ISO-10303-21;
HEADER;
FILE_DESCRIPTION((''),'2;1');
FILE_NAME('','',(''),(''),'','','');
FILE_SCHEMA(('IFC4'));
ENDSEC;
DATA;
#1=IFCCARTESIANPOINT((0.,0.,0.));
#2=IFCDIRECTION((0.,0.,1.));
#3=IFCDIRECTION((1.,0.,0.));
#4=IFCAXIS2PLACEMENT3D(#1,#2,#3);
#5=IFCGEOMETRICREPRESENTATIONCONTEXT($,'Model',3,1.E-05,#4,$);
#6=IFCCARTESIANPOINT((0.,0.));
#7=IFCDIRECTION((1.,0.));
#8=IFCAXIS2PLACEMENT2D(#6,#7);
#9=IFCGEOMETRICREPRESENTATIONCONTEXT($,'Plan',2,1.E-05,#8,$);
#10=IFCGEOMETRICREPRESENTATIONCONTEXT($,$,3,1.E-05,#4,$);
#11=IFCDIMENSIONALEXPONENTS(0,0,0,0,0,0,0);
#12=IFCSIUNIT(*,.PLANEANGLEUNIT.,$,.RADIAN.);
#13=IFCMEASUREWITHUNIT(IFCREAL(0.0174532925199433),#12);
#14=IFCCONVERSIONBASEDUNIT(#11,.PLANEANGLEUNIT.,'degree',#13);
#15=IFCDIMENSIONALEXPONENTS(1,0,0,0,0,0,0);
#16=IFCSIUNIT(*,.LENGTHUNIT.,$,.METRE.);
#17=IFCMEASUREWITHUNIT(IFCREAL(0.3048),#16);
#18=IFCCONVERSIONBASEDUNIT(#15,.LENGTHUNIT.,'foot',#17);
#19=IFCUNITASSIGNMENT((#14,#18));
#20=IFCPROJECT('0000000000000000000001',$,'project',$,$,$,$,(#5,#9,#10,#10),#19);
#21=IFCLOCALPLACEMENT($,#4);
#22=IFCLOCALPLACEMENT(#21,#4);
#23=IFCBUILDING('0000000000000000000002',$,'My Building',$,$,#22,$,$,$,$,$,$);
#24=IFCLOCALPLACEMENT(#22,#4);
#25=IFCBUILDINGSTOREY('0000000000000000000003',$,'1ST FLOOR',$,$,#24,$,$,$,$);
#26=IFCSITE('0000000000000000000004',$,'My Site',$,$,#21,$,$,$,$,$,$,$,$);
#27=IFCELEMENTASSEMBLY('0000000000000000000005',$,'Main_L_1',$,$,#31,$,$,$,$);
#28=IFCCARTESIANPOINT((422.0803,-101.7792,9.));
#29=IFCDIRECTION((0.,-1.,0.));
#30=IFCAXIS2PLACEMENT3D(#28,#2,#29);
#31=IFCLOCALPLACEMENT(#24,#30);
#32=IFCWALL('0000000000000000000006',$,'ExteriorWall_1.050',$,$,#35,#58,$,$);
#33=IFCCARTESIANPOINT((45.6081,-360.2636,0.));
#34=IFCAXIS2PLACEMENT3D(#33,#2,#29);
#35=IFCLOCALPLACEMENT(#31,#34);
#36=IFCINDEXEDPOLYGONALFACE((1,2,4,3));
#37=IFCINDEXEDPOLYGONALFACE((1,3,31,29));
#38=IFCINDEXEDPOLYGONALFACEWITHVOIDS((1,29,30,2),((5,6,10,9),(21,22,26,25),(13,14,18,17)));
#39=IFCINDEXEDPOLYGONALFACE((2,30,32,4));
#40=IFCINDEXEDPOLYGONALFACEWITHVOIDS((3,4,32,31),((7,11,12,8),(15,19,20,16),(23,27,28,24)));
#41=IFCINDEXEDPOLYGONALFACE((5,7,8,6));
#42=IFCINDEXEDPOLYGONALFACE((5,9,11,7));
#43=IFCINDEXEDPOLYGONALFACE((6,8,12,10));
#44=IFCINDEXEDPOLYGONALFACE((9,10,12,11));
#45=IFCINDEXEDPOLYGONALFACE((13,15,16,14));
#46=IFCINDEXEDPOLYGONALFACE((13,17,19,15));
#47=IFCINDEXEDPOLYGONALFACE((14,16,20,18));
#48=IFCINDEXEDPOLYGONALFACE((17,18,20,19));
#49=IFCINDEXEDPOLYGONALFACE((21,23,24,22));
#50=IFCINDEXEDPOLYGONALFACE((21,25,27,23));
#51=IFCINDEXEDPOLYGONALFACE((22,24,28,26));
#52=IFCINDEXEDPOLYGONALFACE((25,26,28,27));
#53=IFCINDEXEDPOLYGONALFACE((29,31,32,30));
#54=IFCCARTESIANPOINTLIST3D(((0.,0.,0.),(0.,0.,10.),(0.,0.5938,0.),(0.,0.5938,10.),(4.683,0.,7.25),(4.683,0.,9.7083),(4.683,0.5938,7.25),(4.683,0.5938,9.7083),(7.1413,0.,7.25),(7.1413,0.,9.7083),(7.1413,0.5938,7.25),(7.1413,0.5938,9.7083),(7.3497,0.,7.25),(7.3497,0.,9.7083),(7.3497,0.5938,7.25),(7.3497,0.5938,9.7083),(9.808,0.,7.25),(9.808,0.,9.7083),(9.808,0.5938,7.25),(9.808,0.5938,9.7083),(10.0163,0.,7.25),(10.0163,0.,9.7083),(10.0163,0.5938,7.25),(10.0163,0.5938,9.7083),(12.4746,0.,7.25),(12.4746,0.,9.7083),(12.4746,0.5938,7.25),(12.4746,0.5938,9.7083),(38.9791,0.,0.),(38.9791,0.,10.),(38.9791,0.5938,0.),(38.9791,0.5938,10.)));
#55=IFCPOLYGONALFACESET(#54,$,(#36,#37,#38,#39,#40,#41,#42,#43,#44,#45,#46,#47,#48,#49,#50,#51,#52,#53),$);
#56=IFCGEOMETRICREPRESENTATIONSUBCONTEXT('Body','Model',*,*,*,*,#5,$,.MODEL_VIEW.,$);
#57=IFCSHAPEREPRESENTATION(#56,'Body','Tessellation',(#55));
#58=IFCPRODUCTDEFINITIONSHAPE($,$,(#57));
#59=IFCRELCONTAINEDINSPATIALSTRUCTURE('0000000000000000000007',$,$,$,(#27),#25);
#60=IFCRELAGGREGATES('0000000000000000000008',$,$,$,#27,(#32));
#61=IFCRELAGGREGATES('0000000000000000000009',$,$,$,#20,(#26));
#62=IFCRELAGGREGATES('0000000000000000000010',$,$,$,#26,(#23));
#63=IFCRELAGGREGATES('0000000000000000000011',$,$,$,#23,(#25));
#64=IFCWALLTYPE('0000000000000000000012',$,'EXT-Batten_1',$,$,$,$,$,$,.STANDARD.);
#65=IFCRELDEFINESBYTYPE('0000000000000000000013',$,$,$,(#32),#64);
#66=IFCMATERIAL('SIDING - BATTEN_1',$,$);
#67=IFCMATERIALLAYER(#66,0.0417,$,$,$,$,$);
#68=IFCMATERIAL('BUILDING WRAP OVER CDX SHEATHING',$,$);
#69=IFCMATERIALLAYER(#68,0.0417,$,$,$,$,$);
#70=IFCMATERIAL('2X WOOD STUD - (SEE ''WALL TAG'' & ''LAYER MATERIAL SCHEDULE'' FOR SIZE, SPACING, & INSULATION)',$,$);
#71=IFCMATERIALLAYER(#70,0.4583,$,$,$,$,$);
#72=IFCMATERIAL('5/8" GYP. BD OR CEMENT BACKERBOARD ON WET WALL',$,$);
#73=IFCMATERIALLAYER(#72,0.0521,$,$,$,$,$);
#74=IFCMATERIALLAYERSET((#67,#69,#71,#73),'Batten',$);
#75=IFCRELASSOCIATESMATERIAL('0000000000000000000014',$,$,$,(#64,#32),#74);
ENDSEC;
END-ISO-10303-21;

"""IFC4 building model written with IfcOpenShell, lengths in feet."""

from ifc_helpers import new_model, entity, si_unit, converted_unit, frame, origin_with_axes, origin_2d_with_axis, place, context, subcontext, project, spatial, line, indexed_curve, outline, extrude, source, transform, mapped, material, layer, layer_set, layer_usage, type_object, element, aggregate, save


model = new_model("IFC4")

# Units and contexts
model_context = context("Model", 3, precision=1e-05, world=origin_with_axes())
plan_context = context("Plan", 2, precision=1e-05, world=origin_2d_with_axis())
context_of_model = context(None, 3, precision=1e-05, world=origin_with_axes())
body_context = subcontext(model_context, "Body", "Model", "MODEL_VIEW")
ifc_project = project(units=[converted_unit("PLANEANGLEUNIT", "degree", entity("IfcReal", 0.0174532925199433), si_unit("PLANEANGLEUNIT", "RADIAN"), dimensions=[0, 0, 0, 0, 0, 0, 0]), converted_unit("LENGTHUNIT", "foot", entity("IfcReal", 0.3048), si_unit("LENGTHUNIT", "METRE"), dimensions=[1, 0, 0, 0, 0, 0, 0])], contexts=[model_context, plan_context, context_of_model, context_of_model])

# Site, building, storey
site_placement = place(None, origin_with_axes())
site = spatial("IfcSite", under=ifc_project, at=site_placement, Name="My Site")
building_placement = place(site_placement, origin_with_axes())
building = spatial("IfcBuilding", under=site, at=building_placement, Name="My Building")
storey_placement = place(building_placement, origin_with_axes())
storey = spatial("IfcBuildingStorey", under=building, at=storey_placement, Name="1ST FLOOR")

# Element assembly
assembly_placement = place(storey_placement, frame((422.0803, -101.7792, 9.0), z_axis=(0.0, 0.0, 1.0), x_axis=(0.0, -1.0, 0.0)))
assembly = element("IfcElementAssembly", 1, at=assembly_placement, inside=storey, Name="Main_L_1")

# Shared definitions
ifc_material_1 = material(Name="SIDING - BATTEN_1")
ifc_layer_1 = layer(ifc_material_1, 0.0417)
ifc_material_2 = material(Name="BUILDING WRAP OVER CDX SHEATHING")
ifc_layer_2 = layer(ifc_material_2, 0.0417)
ifc_material_3 = material(Name="2X WOOD STUD - (SEE 'WALL TAG' & 'LAYER MATERIAL SCHEDULE' FOR SIZE, SPACING, & INSULATION)")
ifc_layer_3 = layer(ifc_material_3, 0.4583)
ifc_material_4 = material(Name="5/8\" GYP. BD OR CEMENT BACKERBOARD ON WET WALL")
ifc_layer_4 = layer(ifc_material_4, 0.0521)
ifc_layer_set_1 = layer_set([ifc_layer_1, ifc_layer_2, ifc_layer_3, ifc_layer_4], Name="Batten")
wall_type_1 = type_object("IfcWallType", Name="EXT-Batten_1", PredefinedType="STANDARD", material=ifc_layer_set_1)

# Wall, openings
ifc_layer_usage_1 = layer_usage(ifc_layer_set_1, "AXIS2", "POSITIVE", 0.0)
wall_1_placement = place(assembly_placement, frame((45.6081, -360.2636, 0.0), z_axis=(0.0, 0.0, 1.0), x_axis=(0.0, -1.0, 0.0)))
wall_1 = element("IfcWall", 2, at=wall_1_placement, type_object=wall_type_1, material=ifc_layer_usage_1, Name="ExteriorWall_1.050", context=body_context, shape_type="SweptSolid", body=[
    extrude(outline(indexed_curve([(0.0, 0.0), (0.0, 0.5938), (38.9791, 0.5938), (38.9791, 0.0), (0.0, 0.0)], self_intersect=False)), origin_with_axes(), (0.0, 0.0, 1.0), 10.0),
])
shared_shape_1 = source(origin_with_axes(), body_context, "Body", "SweptSolid", [
    extrude(outline(indexed_curve([(0.0, 0.0), (2.4583, 0.0), (2.4583, 2.4583), (0.0, 2.4583)], segments=[line(1, 2, 3, 4, 1)])), frame((0.0, -1.9685, 0.0), z_axis=(0.0, -1.0, 0.0), x_axis=(1.0, 0.0, 0.0)), (0.0, 0.0, -1.0), 3.937),
])
opening_1_placement = place(wall_1_placement, frame((7.3497, 0.0, 7.25), z_axis=(0.0, 0.0, 1.0), x_axis=(1.0, 0.0, 0.0)))
element("IfcOpeningElement", 3, at=opening_1_placement, cuts=wall_1, PredefinedType="OPENING", context=body_context, shape_type="MappedRepresentation", body=[
    mapped(shared_shape_1, transform((0.0, 0.0, 0.0), x_axis=(1.0, 0.0, 0.0), y_axis=(0.0, 1.0, 0.0), z_axis=(0.0, 0.0, 1.0), scale=1.0)),
])
opening_2_placement = place(wall_1_placement, frame((4.683, 0.0, 7.25), z_axis=(0.0, 0.0, 1.0), x_axis=(1.0, 0.0, 0.0)))
element("IfcOpeningElement", 4, at=opening_2_placement, cuts=wall_1, PredefinedType="OPENING", context=body_context, shape_type="MappedRepresentation", body=[
    mapped(shared_shape_1, transform((0.0, 0.0, 0.0), x_axis=(1.0, 0.0, 0.0), y_axis=(0.0, 1.0, 0.0), z_axis=(0.0, 0.0, 1.0), scale=1.0)),
])
opening_3_placement = place(wall_1_placement, frame((10.0163, 0.0, 7.25), z_axis=(0.0, 0.0, 1.0), x_axis=(1.0, 0.0, 0.0)))
element("IfcOpeningElement", 5, at=opening_3_placement, cuts=wall_1, PredefinedType="OPENING", context=body_context, shape_type="MappedRepresentation", body=[
    mapped(shared_shape_1, transform((0.0, 0.0, 0.0), x_axis=(1.0, 0.0, 0.0), y_axis=(0.0, 1.0, 0.0), z_axis=(0.0, 0.0, 1.0), scale=1.0)),
])

aggregate(assembly, [wall_1])

save(model, "model.ifc")
